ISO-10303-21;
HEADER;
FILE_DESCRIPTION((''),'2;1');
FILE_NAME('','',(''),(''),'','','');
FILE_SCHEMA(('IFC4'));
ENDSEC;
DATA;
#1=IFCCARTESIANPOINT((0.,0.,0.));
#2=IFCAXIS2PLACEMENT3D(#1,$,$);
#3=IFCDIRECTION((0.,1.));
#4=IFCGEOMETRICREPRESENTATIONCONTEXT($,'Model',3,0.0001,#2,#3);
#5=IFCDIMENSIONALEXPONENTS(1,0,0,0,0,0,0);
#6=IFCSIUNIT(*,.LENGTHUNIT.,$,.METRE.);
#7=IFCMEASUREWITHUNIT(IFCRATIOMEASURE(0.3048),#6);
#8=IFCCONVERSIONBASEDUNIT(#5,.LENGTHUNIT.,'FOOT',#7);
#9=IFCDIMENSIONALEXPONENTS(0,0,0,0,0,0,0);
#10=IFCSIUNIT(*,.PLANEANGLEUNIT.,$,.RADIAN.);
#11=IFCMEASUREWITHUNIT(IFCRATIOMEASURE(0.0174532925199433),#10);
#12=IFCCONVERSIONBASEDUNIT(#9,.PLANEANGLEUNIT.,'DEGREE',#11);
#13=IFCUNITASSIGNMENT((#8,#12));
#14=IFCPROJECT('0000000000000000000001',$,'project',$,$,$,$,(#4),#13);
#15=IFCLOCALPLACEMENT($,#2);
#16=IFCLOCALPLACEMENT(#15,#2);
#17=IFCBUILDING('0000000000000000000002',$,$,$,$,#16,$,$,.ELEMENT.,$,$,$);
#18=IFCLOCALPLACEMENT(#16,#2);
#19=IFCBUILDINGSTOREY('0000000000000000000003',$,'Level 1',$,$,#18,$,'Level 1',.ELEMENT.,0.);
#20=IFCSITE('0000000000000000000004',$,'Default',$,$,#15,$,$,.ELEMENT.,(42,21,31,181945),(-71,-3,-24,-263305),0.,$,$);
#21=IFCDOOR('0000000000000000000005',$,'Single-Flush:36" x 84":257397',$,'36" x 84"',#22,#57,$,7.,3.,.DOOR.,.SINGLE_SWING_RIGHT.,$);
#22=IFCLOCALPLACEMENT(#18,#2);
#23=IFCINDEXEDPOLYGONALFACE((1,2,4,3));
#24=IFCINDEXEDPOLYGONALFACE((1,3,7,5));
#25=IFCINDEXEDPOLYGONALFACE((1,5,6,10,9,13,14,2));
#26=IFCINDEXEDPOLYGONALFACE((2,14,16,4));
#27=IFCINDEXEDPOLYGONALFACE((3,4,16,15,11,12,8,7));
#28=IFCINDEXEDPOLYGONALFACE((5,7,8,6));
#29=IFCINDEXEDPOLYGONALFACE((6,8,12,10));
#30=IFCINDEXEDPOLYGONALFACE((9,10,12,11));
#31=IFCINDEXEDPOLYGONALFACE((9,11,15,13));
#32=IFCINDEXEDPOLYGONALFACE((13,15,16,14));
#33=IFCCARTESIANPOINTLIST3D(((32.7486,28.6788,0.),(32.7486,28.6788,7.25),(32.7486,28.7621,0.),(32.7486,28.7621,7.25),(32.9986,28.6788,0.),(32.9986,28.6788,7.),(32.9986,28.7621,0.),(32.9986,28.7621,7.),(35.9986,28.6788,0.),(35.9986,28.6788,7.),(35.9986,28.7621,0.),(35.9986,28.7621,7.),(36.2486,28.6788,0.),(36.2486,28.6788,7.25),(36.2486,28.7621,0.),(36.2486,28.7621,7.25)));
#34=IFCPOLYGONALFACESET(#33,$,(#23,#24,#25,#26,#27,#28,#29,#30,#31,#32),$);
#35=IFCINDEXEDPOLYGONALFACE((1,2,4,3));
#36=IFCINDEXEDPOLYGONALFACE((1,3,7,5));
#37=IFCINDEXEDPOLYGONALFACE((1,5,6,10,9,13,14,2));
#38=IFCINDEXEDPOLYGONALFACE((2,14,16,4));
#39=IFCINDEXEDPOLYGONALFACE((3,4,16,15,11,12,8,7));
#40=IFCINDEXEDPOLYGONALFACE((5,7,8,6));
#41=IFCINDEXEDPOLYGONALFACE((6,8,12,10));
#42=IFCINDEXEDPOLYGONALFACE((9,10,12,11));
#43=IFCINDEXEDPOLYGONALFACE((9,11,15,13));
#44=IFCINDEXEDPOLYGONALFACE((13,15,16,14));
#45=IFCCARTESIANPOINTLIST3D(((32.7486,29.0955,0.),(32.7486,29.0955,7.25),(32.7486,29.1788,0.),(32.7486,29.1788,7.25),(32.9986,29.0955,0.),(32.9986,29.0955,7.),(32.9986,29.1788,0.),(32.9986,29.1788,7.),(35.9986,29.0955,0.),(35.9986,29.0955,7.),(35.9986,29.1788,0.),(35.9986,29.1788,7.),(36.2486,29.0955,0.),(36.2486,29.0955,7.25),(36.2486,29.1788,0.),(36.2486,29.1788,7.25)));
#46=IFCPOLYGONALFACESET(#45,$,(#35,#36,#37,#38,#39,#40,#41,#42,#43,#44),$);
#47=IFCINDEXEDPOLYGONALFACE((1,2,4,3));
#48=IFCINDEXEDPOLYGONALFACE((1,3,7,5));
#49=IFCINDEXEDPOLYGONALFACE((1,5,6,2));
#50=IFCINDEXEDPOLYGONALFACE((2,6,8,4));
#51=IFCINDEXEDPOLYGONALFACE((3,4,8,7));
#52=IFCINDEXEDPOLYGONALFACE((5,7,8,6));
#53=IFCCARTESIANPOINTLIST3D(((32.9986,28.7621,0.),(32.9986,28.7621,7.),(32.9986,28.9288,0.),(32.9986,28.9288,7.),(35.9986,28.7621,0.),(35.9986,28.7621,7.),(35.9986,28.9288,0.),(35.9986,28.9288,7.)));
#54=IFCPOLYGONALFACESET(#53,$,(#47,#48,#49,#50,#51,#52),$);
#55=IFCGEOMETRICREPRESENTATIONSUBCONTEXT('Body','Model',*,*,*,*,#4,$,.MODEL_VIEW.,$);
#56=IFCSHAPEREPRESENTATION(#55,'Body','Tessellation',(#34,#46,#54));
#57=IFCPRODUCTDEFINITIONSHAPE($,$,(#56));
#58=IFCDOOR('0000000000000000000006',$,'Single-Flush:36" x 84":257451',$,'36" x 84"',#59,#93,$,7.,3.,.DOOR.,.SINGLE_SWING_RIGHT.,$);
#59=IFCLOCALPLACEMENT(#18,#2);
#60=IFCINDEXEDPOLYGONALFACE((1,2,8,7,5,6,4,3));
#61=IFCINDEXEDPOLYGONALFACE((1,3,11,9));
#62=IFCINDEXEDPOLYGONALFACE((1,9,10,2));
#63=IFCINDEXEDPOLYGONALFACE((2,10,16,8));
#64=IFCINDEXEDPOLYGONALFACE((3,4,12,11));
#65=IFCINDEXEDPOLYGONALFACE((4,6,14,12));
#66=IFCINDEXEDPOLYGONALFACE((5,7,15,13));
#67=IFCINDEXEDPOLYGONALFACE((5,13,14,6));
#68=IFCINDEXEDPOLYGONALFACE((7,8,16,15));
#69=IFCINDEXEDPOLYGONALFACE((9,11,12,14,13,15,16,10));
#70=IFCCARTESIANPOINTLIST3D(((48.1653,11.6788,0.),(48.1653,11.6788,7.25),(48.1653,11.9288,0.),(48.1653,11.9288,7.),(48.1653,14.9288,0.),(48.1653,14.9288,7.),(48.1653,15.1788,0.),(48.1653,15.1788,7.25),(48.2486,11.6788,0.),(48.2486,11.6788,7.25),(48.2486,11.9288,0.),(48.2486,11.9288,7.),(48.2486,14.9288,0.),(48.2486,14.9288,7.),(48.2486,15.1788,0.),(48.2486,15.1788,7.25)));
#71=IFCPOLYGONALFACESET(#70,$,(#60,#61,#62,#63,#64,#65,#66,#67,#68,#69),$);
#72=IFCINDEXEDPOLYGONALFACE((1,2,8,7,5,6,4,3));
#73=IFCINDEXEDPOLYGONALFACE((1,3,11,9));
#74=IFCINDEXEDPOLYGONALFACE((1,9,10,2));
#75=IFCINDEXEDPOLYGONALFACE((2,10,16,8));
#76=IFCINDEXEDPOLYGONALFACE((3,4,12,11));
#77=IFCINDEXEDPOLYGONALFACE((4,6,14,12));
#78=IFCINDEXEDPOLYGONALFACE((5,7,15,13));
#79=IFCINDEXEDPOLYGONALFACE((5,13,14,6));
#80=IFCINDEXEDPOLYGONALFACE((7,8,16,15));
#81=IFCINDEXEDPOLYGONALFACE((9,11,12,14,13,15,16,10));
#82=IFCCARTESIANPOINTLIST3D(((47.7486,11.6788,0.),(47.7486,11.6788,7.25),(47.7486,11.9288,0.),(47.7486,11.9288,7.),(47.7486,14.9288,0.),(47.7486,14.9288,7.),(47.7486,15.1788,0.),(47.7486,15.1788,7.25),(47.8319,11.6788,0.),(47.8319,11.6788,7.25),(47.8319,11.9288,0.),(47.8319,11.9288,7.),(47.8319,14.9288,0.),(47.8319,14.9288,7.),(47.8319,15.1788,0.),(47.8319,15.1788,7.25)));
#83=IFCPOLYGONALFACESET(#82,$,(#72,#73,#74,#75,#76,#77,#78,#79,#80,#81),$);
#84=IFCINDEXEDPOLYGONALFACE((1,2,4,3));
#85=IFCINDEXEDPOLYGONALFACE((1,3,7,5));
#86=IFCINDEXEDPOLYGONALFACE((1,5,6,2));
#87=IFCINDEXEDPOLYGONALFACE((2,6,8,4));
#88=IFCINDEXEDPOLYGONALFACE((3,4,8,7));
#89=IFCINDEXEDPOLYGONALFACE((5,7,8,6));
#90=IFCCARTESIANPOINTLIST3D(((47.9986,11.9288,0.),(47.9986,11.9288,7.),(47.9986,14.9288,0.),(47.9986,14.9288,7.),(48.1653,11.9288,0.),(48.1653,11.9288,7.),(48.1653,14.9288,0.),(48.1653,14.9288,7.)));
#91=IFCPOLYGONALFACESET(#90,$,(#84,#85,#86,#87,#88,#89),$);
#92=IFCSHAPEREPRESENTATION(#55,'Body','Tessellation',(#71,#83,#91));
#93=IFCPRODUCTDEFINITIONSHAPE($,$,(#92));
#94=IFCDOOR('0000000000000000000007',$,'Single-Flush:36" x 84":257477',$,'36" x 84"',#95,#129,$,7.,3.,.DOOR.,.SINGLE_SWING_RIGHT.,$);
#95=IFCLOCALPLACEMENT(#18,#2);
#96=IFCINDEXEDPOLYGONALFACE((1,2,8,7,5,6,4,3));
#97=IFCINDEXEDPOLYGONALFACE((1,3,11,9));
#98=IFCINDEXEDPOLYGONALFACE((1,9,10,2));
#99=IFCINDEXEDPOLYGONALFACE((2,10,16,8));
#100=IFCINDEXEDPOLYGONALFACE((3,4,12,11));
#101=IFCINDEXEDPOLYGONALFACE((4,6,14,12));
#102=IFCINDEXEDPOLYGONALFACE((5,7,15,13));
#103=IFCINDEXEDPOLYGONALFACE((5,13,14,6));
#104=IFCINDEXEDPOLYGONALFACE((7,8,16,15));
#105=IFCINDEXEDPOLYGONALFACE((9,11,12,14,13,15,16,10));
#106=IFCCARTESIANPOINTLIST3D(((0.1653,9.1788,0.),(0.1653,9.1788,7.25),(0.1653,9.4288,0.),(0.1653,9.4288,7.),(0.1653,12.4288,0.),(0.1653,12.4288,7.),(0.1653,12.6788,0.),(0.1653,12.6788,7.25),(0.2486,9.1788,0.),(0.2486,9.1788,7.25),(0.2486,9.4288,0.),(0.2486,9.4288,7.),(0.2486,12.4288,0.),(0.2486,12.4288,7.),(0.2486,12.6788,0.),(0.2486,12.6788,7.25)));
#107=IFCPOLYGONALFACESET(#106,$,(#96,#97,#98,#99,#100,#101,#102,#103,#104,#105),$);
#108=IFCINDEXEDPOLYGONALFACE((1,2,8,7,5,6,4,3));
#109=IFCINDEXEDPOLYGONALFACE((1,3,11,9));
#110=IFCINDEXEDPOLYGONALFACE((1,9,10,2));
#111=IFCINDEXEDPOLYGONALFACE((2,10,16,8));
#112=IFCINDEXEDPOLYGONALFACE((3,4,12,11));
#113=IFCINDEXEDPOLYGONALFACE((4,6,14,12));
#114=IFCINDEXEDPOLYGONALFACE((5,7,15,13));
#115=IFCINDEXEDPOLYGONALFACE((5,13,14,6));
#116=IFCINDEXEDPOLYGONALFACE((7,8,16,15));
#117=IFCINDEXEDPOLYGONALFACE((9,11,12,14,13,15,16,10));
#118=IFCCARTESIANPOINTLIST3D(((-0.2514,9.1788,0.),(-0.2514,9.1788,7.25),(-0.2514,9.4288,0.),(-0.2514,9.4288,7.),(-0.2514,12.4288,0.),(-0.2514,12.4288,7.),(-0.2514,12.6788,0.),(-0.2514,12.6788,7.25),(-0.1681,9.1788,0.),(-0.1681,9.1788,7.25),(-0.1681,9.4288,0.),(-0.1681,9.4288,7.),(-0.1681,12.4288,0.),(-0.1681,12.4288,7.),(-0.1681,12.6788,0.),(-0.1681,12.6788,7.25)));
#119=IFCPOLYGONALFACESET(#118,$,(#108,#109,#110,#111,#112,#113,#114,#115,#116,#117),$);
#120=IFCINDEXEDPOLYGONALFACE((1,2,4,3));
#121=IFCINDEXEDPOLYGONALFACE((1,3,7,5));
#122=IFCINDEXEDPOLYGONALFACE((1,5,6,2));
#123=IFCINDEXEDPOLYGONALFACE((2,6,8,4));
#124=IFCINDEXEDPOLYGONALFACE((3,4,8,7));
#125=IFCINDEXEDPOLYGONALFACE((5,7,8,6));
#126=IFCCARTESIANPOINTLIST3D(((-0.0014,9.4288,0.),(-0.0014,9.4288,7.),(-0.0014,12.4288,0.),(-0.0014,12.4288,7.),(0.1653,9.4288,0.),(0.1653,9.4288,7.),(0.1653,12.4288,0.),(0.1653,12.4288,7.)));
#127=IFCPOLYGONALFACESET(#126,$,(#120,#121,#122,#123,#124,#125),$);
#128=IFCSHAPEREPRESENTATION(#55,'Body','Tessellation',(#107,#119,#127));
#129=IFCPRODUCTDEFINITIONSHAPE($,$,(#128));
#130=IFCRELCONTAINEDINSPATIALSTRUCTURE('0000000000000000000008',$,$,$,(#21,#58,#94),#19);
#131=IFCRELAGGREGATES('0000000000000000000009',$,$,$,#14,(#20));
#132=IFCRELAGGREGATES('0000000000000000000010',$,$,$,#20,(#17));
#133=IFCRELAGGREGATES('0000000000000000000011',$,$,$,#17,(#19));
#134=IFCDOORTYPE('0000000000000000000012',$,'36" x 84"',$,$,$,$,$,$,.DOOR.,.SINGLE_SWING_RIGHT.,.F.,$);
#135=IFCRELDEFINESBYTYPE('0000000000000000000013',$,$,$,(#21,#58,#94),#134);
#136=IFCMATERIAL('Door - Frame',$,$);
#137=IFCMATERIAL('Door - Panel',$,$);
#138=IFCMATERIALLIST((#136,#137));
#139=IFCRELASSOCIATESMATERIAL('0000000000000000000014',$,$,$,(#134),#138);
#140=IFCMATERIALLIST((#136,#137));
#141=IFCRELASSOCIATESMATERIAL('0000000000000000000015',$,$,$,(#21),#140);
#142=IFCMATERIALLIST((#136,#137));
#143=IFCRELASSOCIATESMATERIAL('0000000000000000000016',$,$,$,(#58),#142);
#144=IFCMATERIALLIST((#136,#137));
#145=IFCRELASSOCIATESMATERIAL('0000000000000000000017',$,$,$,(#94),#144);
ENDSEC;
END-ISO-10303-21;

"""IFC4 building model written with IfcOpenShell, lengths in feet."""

from ifc_helpers import new_model, entity, si_unit, converted_unit, direction, frame, frame_2d, origin, place, context, subcontext, project, spatial, polyline, rectangle, outline, extrude, source, transform, mapped, material, material_list, type_object, type_shapes, element, save


model = new_model("IFC4")

# Units and contexts
model_context = context("Model", 3, precision=0.0001, world=origin(), true_north=direction((0.0, 1.0)))
body_context = subcontext(model_context, "Body", "Model", "MODEL_VIEW")
ifc_project = project(units=[converted_unit("LENGTHUNIT", "FOOT", entity("IfcRatioMeasure", 0.3048), si_unit("LENGTHUNIT", "METRE"), dimensions=[1, 0, 0, 0, 0, 0, 0]), converted_unit("PLANEANGLEUNIT", "DEGREE", entity("IfcRatioMeasure", 0.0174532925199433), si_unit("PLANEANGLEUNIT", "RADIAN"), dimensions=[0, 0, 0, 0, 0, 0, 0])], contexts=[model_context])

# Site, building, storey
site_placement = place(None, origin())
site = spatial("IfcSite", under=ifc_project, at=site_placement, Name="Default", CompositionType="ELEMENT", RefLatitude=(42, 21, 31, 181945), RefLongitude=(-71, -3, -24, -263305), RefElevation=0.0)
building_placement = place(site_placement, origin())
building = spatial("IfcBuilding", under=site, at=building_placement, CompositionType="ELEMENT")
storey_placement = place(building_placement, origin())
storey = spatial("IfcBuildingStorey", under=building, at=storey_placement, Name="Level 1", LongName="Level 1", CompositionType="ELEMENT", Elevation=0.0)

# Shared definitions
placement_1 = place(storey_placement, frame((-0.1681, 28.9288, 0.0)))
placement_2 = place(storey_placement, frame((-0.0014, -6.9045, 0.0), z_axis=(0.0, 0.0, 1.0), x_axis=(0.0, 1.0, 0.0)))

# Doors
ifc_material_1 = material(Name="Door - Frame")
ifc_material_2 = material(Name="Door - Panel")
ifc_material_list_1 = material_list([ifc_material_1, ifc_material_2])
door_type = type_object("IfcDoorType", Name="36\" x 84\"", OperationType="SINGLE_SWING_RIGHT", ParameterTakesPrecedence=False, PredefinedType="DOOR", material=ifc_material_list_1)
shared_shape_1 = source(origin(), body_context, "Body", "SweptSolid", [
    extrude(outline(polyline([(-1.75, -3.6875), (1.75, -3.6875), (1.75, 3.5625), (1.5, 3.5625), (1.5, -3.4375), (-1.5, -3.4375), (-1.5, 3.5625), (-1.75, 3.5625), (-1.75, -3.6875)])), frame((1.5, 0.3333, 3.5625), z_axis=(0.0, 1.0, 0.0), x_axis=(1.0, 0.0, 0.0)), (0.0, 0.0, 1.0), 0.0833),
    extrude(outline(polyline([(-3.6875, -1.75), (3.5625, -1.75), (3.5625, -1.5), (-3.4375, -1.5), (-3.4375, 1.5), (3.5625, 1.5), (3.5625, 1.75), (-3.6875, 1.75), (-3.6875, -1.75)])), frame((1.5, -0.0833, 3.5625), z_axis=(0.0, 1.0, 0.0), x_axis=(0.0, 0.0, -1.0)), (0.0, 0.0, 1.0), 0.0833),
    extrude(rectangle(XDim=0.1667, YDim=3.0, at=frame_2d((0.0, 0.0), x_axis=(1.0, 0.0))), frame((1.5, 0.25, 0.0), z_axis=(0.0, 0.0, 1.0), x_axis=(0.0, 1.0, 0.0)), (0.0, 0.0, 1.0), 7.0),
])
type_shapes(door_type, [shared_shape_1])
ifc_material_list_2 = material_list([ifc_material_1, ifc_material_2])
placement_3 = place(placement_1, frame((36.1667, 0.1667, 0.0)))
door_1_placement = place(placement_3, frame((0.0, 0.0, 0.0), z_axis=(0.0, 0.0, 1.0), x_axis=(-1.0, 0.0, 0.0)))
element("IfcDoor", 1, at=door_1_placement, inside=storey, type_object=door_type, material=ifc_material_list_2, Name="Single-Flush:36\" x 84\":257397", ObjectType="36\" x 84\"", OperationType="SINGLE_SWING_RIGHT", OverallHeight=7.0, OverallWidth=3.0, PredefinedType="DOOR", context=body_context, shape_type="MappedRepresentation", body=[
    mapped(shared_shape_1, transform((0.0, 0.0, 0.0), scale=1.0)),
])
ifc_material_list_3 = material_list([ifc_material_1, ifc_material_2])
placement_4 = place(storey_placement, frame((47.9986, 28.7621, 0.0), z_axis=(0.0, 0.0, 1.0), x_axis=(0.0, -1.0, 0.0)))
placement_5 = place(placement_4, frame((13.8333, -0.1667, 0.0)))
door_2_placement = place(placement_5, origin())
element("IfcDoor", 2, at=door_2_placement, inside=storey, type_object=door_type, material=ifc_material_list_3, Name="Single-Flush:36\" x 84\":257451", ObjectType="36\" x 84\"", OperationType="SINGLE_SWING_RIGHT", OverallHeight=7.0, OverallWidth=3.0, PredefinedType="DOOR", context=body_context, shape_type="MappedRepresentation", body=[
    mapped(shared_shape_1, transform((0.0, 0.0, 0.0), scale=1.0)),
])
ifc_material_list_4 = material_list([ifc_material_1, ifc_material_2])
placement_6 = place(placement_2, frame((19.3333, 0.1667, 0.0)))
door_3_placement = place(placement_6, frame((0.0, 0.0, 0.0), z_axis=(0.0, 0.0, 1.0), x_axis=(-1.0, 0.0, 0.0)))
element("IfcDoor", 3, at=door_3_placement, inside=storey, type_object=door_type, material=ifc_material_list_4, Name="Single-Flush:36\" x 84\":257477", ObjectType="36\" x 84\"", OperationType="SINGLE_SWING_RIGHT", OverallHeight=7.0, OverallWidth=3.0, PredefinedType="DOOR", context=body_context, shape_type="MappedRepresentation", body=[
    mapped(shared_shape_1, transform((0.0, 0.0, 0.0), scale=1.0)),
])

save(model, "model.ifc")
